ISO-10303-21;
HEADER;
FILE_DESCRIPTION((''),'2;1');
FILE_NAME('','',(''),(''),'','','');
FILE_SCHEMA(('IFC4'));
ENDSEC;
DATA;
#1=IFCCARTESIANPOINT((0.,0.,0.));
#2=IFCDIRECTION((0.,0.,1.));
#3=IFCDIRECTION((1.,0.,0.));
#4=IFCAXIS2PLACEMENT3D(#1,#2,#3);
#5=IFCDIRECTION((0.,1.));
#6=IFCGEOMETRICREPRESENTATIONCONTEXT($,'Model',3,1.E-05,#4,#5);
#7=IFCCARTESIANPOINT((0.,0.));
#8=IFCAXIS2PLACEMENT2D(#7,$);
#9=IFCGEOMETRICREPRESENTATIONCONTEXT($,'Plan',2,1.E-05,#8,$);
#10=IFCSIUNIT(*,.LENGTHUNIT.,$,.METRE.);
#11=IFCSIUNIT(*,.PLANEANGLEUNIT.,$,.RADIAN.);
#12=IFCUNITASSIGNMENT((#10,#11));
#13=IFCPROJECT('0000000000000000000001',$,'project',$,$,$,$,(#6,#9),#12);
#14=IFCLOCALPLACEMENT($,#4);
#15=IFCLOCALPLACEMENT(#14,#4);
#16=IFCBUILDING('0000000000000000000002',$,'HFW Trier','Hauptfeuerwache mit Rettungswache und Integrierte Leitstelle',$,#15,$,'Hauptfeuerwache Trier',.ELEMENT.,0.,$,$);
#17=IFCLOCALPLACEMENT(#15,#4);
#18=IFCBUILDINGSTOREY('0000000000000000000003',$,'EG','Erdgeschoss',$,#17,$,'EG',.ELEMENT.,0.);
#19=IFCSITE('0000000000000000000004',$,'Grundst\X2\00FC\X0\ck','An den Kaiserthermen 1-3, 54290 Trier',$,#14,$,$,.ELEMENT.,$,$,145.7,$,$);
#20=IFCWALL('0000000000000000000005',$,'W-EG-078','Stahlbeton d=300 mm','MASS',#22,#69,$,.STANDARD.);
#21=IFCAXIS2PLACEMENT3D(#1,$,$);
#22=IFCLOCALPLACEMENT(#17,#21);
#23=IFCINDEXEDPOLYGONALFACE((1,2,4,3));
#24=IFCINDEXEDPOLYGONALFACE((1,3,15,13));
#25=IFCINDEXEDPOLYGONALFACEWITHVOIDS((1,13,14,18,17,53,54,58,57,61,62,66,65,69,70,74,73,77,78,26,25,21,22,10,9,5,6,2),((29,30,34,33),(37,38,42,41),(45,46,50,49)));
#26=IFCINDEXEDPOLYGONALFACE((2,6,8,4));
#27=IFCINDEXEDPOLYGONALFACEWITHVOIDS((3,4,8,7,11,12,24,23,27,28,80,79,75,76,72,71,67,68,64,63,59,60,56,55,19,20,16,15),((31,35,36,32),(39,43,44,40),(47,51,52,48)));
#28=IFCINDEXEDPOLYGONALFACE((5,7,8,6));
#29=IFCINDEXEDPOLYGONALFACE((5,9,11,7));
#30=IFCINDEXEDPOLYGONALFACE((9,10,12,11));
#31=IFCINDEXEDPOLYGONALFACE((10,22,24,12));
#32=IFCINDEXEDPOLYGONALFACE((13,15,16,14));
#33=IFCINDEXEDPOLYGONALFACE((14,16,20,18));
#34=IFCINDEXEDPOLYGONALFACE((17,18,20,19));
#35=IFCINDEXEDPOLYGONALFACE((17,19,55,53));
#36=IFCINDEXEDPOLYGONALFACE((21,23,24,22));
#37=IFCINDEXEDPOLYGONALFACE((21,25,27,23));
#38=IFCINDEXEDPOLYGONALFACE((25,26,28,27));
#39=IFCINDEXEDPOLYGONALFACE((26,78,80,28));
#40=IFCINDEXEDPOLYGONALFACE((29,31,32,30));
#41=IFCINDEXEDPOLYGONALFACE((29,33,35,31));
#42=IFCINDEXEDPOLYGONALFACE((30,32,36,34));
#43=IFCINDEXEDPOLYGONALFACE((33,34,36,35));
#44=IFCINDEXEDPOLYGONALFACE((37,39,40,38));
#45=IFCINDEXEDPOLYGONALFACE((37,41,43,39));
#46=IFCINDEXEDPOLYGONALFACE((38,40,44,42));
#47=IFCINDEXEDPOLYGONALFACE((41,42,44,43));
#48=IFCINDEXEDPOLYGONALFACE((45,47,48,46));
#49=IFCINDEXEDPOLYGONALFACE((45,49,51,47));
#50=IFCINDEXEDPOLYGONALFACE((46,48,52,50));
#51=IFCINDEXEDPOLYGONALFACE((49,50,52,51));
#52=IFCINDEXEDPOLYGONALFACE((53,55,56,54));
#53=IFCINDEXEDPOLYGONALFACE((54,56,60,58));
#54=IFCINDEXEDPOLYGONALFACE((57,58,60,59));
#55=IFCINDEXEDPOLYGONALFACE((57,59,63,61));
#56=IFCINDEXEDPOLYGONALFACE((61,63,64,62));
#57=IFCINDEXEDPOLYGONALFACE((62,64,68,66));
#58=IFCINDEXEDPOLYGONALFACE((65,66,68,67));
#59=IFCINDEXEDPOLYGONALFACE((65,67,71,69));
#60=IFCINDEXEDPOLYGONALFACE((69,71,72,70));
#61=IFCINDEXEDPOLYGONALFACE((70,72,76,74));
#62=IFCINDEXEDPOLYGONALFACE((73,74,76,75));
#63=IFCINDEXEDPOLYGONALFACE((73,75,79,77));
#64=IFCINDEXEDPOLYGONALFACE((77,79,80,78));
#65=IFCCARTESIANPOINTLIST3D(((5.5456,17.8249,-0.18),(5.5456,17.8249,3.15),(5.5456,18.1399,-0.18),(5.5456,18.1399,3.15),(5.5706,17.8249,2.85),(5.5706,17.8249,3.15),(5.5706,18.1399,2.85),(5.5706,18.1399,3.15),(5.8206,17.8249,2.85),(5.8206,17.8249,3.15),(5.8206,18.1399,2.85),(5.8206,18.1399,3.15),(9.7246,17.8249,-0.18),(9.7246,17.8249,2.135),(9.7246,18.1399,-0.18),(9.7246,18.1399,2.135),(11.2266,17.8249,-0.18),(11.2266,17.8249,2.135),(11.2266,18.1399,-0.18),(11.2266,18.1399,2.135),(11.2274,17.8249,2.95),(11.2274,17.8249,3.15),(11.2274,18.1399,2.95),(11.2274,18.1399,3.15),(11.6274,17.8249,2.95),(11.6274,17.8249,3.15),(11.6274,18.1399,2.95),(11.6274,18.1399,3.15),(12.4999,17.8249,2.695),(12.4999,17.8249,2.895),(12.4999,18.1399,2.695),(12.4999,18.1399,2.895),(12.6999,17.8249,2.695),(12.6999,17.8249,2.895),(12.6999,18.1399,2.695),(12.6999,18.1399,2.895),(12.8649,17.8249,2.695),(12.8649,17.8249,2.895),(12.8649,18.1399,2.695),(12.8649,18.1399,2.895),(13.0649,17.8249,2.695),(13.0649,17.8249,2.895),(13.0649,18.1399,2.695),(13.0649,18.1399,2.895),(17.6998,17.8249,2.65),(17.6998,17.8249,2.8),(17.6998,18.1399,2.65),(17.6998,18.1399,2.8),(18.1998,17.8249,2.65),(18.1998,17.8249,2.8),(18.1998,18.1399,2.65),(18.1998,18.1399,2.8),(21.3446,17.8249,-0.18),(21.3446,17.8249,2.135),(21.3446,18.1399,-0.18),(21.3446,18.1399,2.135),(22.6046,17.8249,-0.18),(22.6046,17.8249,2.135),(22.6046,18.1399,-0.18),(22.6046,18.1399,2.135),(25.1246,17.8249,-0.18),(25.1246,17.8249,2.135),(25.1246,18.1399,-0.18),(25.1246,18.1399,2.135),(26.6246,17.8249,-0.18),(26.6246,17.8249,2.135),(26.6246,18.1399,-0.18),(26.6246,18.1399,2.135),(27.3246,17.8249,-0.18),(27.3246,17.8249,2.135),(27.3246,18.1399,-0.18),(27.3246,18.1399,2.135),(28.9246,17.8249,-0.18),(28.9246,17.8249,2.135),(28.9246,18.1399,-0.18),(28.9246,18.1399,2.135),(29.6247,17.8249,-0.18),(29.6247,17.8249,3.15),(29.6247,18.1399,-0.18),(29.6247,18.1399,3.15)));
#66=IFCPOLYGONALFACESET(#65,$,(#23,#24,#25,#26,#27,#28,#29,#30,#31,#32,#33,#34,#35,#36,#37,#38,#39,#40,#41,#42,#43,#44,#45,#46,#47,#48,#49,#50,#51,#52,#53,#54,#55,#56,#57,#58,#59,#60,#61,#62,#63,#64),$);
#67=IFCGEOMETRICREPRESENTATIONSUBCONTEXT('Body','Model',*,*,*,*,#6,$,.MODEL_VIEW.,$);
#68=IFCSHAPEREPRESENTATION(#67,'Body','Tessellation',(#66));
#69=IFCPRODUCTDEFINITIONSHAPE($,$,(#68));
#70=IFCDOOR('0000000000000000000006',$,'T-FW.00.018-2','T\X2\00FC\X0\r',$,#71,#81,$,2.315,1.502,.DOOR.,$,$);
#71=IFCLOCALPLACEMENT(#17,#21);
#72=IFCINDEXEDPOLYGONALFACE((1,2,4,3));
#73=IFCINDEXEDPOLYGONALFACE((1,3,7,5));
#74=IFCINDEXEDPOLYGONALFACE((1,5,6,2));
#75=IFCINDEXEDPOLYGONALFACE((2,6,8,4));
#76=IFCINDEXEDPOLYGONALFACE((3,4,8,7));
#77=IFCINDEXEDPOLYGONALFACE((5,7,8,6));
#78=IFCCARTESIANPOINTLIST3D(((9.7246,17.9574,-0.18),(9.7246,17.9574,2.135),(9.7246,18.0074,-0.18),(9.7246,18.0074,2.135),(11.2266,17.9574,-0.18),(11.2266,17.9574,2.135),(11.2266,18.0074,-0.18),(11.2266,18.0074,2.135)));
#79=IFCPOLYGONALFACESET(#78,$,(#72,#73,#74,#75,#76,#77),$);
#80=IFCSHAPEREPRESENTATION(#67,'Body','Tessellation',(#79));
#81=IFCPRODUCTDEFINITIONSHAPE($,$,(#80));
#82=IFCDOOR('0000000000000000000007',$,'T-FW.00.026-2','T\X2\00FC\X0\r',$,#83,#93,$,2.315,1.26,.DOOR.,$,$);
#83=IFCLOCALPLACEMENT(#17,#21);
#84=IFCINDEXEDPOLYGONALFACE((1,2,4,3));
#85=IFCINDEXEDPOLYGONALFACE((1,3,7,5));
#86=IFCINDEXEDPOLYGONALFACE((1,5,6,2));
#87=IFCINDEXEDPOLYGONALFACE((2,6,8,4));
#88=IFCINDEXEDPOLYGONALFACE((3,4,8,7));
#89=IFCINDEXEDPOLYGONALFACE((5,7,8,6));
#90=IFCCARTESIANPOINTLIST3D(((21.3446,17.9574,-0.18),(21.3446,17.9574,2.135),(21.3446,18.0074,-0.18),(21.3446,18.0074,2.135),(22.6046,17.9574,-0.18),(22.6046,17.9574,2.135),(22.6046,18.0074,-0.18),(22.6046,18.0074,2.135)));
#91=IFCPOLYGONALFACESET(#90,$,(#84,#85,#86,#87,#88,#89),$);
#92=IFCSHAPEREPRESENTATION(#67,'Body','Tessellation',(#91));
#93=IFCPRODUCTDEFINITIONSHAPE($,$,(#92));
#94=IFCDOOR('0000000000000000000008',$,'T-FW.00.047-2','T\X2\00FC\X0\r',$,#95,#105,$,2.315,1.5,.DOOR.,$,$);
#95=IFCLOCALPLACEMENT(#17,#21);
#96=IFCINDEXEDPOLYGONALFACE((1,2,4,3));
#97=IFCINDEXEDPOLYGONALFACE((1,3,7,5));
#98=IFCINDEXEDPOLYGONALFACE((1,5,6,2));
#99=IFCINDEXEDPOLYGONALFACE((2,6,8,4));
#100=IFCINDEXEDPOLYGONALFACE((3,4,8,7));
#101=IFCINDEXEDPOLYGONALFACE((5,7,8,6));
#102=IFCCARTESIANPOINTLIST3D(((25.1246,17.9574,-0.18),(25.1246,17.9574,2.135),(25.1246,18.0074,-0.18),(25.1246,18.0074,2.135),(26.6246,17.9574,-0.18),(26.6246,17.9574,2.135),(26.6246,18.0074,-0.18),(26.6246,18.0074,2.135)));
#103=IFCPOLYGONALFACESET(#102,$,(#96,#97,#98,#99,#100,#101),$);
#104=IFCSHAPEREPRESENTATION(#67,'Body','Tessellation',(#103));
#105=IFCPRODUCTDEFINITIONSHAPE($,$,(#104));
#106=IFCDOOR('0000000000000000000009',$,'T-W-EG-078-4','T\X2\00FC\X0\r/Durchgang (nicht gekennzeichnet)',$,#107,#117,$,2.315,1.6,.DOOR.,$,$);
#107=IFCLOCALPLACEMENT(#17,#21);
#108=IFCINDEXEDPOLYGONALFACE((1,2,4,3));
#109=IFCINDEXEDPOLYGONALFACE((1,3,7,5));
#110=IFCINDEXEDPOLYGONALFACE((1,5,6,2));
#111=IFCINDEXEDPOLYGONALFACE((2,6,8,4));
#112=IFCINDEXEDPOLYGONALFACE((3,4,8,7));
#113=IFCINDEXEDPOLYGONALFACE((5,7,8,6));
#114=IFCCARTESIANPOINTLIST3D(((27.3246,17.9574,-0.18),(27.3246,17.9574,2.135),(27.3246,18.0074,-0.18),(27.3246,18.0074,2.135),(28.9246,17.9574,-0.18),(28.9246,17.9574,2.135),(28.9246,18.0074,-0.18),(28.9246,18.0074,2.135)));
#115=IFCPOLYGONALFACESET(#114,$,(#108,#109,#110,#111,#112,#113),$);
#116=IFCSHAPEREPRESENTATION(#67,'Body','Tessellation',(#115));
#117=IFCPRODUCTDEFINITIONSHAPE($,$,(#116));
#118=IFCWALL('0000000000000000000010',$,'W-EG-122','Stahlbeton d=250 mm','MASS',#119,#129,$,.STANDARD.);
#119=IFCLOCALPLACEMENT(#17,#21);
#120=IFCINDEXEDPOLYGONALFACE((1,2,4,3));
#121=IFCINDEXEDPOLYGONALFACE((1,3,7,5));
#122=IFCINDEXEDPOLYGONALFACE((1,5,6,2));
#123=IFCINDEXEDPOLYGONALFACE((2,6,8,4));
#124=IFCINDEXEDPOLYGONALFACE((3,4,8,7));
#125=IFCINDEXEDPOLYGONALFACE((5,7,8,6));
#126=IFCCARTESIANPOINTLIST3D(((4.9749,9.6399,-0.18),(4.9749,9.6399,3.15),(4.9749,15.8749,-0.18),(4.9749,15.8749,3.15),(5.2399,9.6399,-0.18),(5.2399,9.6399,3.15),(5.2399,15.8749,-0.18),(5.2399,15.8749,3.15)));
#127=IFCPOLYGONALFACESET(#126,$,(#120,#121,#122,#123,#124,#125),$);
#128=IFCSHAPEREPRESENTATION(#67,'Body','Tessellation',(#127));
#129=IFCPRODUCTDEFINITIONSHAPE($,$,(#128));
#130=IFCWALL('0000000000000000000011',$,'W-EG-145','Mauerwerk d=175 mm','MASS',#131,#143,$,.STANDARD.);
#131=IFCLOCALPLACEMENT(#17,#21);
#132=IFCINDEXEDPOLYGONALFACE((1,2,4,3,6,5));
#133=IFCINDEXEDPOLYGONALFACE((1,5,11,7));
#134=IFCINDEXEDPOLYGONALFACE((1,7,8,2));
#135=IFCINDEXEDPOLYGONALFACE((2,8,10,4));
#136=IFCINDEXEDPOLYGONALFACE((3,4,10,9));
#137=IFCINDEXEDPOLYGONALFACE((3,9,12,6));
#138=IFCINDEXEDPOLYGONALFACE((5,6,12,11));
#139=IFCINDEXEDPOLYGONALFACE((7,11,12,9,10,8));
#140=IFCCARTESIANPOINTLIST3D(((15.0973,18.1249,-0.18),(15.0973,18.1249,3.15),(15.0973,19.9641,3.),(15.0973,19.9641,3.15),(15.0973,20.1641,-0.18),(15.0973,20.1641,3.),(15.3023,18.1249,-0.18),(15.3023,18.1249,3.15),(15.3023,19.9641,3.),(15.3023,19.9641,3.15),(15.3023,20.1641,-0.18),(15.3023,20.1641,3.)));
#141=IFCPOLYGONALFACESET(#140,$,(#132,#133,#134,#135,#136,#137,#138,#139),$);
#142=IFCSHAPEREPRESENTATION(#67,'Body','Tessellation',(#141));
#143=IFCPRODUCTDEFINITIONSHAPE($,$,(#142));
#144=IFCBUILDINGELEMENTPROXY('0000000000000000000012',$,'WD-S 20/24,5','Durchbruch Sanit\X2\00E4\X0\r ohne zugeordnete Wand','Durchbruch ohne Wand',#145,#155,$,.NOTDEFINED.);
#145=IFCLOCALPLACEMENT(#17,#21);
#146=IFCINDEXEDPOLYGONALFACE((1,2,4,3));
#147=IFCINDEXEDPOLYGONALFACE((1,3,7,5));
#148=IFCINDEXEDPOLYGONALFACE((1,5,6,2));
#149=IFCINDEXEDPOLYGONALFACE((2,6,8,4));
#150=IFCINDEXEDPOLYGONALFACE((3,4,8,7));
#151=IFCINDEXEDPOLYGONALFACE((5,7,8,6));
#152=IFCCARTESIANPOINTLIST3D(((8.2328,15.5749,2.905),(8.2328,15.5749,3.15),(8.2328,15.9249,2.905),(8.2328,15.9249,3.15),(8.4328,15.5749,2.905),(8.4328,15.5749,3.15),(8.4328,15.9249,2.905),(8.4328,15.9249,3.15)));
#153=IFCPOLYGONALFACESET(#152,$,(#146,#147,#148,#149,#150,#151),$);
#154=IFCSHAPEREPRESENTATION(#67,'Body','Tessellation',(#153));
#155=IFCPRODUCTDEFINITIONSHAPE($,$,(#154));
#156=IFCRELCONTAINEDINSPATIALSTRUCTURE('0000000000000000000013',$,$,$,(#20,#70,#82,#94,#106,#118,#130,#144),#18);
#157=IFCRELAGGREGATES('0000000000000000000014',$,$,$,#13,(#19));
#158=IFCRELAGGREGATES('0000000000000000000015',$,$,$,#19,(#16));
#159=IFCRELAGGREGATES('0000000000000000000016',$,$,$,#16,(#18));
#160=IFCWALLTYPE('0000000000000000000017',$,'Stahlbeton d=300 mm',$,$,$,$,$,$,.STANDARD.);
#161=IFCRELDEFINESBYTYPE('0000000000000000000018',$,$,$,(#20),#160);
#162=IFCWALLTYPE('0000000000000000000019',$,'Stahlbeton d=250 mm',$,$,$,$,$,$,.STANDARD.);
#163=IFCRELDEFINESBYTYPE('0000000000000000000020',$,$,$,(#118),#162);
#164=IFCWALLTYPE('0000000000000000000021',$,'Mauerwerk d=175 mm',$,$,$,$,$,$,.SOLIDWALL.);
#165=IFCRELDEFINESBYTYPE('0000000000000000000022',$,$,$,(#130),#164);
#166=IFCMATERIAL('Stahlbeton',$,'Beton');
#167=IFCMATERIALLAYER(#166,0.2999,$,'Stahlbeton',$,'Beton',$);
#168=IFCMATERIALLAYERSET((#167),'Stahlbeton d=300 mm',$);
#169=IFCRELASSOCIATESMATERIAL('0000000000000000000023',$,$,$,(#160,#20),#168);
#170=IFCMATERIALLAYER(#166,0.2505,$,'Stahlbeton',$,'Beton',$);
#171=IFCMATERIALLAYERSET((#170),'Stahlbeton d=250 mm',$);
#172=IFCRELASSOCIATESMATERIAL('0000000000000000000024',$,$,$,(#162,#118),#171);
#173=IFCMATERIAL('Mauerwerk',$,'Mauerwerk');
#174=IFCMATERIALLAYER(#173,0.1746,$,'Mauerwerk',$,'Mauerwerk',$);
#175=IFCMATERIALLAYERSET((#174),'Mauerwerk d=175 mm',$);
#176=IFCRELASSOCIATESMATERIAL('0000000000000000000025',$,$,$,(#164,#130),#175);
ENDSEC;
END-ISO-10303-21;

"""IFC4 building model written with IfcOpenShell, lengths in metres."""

from ifc_helpers import new_model, si_unit, direction, frame, frame_2d, origin_with_axes, origin_2d, place, context, subcontext, project, spatial, rectangle, extrude, material, layer, layer_set, layer_usage, type_object, element, fill, save


model = new_model("IFC4")

# Units and contexts
model_context = context("Model", 3, precision=1e-05, world=origin_with_axes(), true_north=direction((0.0, 1.0)))
plan_context = context("Plan", 2, precision=1e-05, world=origin_2d())
body_context = subcontext(model_context, "Body", "Model", "MODEL_VIEW")
ifc_project = project(units=[si_unit("LENGTHUNIT", "METRE"), si_unit("PLANEANGLEUNIT", "RADIAN")], contexts=[model_context, plan_context])

# Site, building, storey
site_placement = place(None, origin_with_axes())
site = spatial("IfcSite", under=ifc_project, at=site_placement, Name="Grundstück", Description="An den Kaiserthermen 1-3, 54290 Trier", CompositionType="ELEMENT", RefElevation=145.7)
building_placement = place(site_placement, origin_with_axes())
building = spatial("IfcBuilding", under=site, at=building_placement, Name="HFW Trier", Description="Hauptfeuerwache mit Rettungswache und Integrierte Leitstelle", LongName="Hauptfeuerwache Trier", CompositionType="ELEMENT", ElevationOfRefHeight=0.0)
storey_placement = place(building_placement, origin_with_axes())
storey = spatial("IfcBuildingStorey", under=building, at=storey_placement, Name="EG", Description="Erdgeschoss", LongName="EG", CompositionType="ELEMENT", Elevation=0.0)

# Wall, openings, doors
ifc_material_1 = material(Name="Stahlbeton", Category="Beton")
ifc_layer_1 = layer(ifc_material_1, 0.2999, Name="Stahlbeton", Category="Beton")
ifc_layer_set_1 = layer_set([ifc_layer_1], Name="Stahlbeton d=300 mm")
ifc_layer_usage_1 = layer_usage(ifc_layer_set_1, "AXIS2", "POSITIVE", -0.1575)
wall_type_1 = type_object("IfcWallType", Name="Stahlbeton d=300 mm", PredefinedType="STANDARD", material=ifc_layer_set_1)
wall_1_placement = place(storey_placement, frame((5.5456, 17.9824, -0.18), z_axis=(0.0, 0.0, 1.0), x_axis=(1.0, 0.0, 0.0)))
wall_1 = element("IfcWall", 1, at=wall_1_placement, inside=storey, type_object=wall_type_1, material=ifc_layer_usage_1, Name="W-EG-078", Description="Stahlbeton d=300 mm", ObjectType="MASS", PredefinedType="STANDARD", context=body_context, shape_type="SweptSolid", body=[
    extrude(rectangle(XDim=24.0791, YDim=0.315, at=frame_2d((12.0396, 0.0))), origin_with_axes(), (0.0, 0.0, 1.0), 3.33),
])
opening_1_placement = place(wall_1_placement, frame((4.179, 0.0, 0.0), z_axis=(0.0, 0.0, 1.0), x_axis=(1.0, 0.0, 0.0)))
opening_1 = element("IfcOpeningElement", 2, at=opening_1_placement, cuts=wall_1, PredefinedType="OPENING", context=body_context, shape_type="SweptSolid", body=[
    extrude(rectangle(XDim=1.502, YDim=0.415, at=frame_2d((0.751, 0.0))), origin_with_axes(), (0.0, 0.0, 1.0), 2.315),
])
opening_2_placement = place(wall_1_placement, frame((15.799, 0.0, 0.0), z_axis=(0.0, 0.0, 1.0), x_axis=(1.0, 0.0, 0.0)))
opening_2 = element("IfcOpeningElement", 3, at=opening_2_placement, cuts=wall_1, PredefinedType="OPENING", context=body_context, shape_type="SweptSolid", body=[
    extrude(rectangle(XDim=1.26, YDim=0.415, at=frame_2d((0.63, 0.0))), origin_with_axes(), (0.0, 0.0, 1.0), 2.315),
])
opening_3_placement = place(wall_1_placement, frame((19.579, 0.0, 0.0), z_axis=(0.0, 0.0, 1.0), x_axis=(1.0, 0.0, 0.0)))
opening_3 = element("IfcOpeningElement", 4, at=opening_3_placement, cuts=wall_1, PredefinedType="OPENING", context=body_context, shape_type="SweptSolid", body=[
    extrude(rectangle(XDim=1.5, YDim=0.415, at=frame_2d((0.75, 0.0))), origin_with_axes(), (0.0, 0.0, 1.0), 2.315),
])
opening_4_placement = place(wall_1_placement, frame((21.779, 0.0, 0.0), z_axis=(0.0, 0.0, 1.0), x_axis=(1.0, 0.0, 0.0)))
opening_4 = element("IfcOpeningElement", 5, at=opening_4_placement, cuts=wall_1, PredefinedType="OPENING", context=body_context, shape_type="SweptSolid", body=[
    extrude(rectangle(XDim=1.6, YDim=0.415, at=frame_2d((0.8, 0.0))), origin_with_axes(), (0.0, 0.0, 1.0), 2.315),
])
opening_5_placement = place(wall_1_placement, origin_with_axes())
element("IfcOpeningElement", 6, at=opening_5_placement, cuts=wall_1, ObjectType="Wanddurchbruch", PredefinedType="OPENING", context=body_context, shape_type="SweptSolid", body=[
    extrude(rectangle(XDim=0.2, YDim=0.415, at=frame_2d((7.0543, 0.0))), frame((0.0, 0.0, 2.875), z_axis=(0.0, 0.0, 1.0), x_axis=(1.0, 0.0, 0.0)), (0.0, 0.0, 1.0), 0.2),
])
opening_6_placement = place(wall_1_placement, origin_with_axes())
element("IfcOpeningElement", 7, at=opening_6_placement, cuts=wall_1, ObjectType="Wanddurchbruch", PredefinedType="OPENING", context=body_context, shape_type="SweptSolid", body=[
    extrude(rectangle(XDim=0.2, YDim=0.415, at=frame_2d((7.4193, 0.0))), frame((0.0, 0.0, 2.875), z_axis=(0.0, 0.0, 1.0), x_axis=(1.0, 0.0, 0.0)), (0.0, 0.0, 1.0), 0.2),
])
opening_7_placement = place(wall_1_placement, origin_with_axes())
element("IfcOpeningElement", 8, at=opening_7_placement, cuts=wall_1, ObjectType="Wanddurchbruch", PredefinedType="OPENING", context=body_context, shape_type="SweptSolid", body=[
    extrude(rectangle(XDim=0.4, YDim=0.415, at=frame_2d((5.8818, 0.0))), frame((0.0, 0.0, 3.13), z_axis=(0.0, 0.0, 1.0), x_axis=(1.0, 0.0, 0.0)), (0.0, 0.0, 1.0), 0.2),
])
opening_8_placement = place(wall_1_placement, origin_with_axes())
element("IfcOpeningElement", 9, at=opening_8_placement, cuts=wall_1, ObjectType="Wanddurchbruch", PredefinedType="OPENING", context=body_context, shape_type="SweptSolid", body=[
    extrude(rectangle(XDim=0.5, YDim=0.415, at=frame_2d((12.4042, 0.0))), frame((0.0, 0.0, 2.83), z_axis=(0.0, 0.0, 1.0), x_axis=(1.0, 0.0, 0.0)), (0.0, 0.0, 1.0), 0.15),
])
opening_9_placement = place(wall_1_placement, origin_with_axes())
element("IfcOpeningElement", 10, at=opening_9_placement, cuts=wall_1, ObjectType="Wanddurchbruch", PredefinedType="OPENING", context=body_context, shape_type="SweptSolid", body=[
    extrude(rectangle(XDim=0.25, YDim=0.415, at=frame_2d((0.15, 0.0))), frame((0.0, 0.0, 3.03), z_axis=(0.0, 0.0, 1.0), x_axis=(1.0, 0.0, 0.0)), (0.0, 0.0, 1.0), 0.3),
])
door_1_placement = place(wall_1_placement, frame((4.179, 0.0, 0.0), z_axis=(0.0, 0.0, 1.0), x_axis=(1.0, 0.0, 0.0)))
door_1 = element("IfcDoor", 11, at=door_1_placement, inside=storey, Name="T-FW.00.018-2", Description="Tür", OverallHeight=2.315, OverallWidth=1.502, PredefinedType="DOOR", context=body_context, shape_type="SweptSolid", body=[
    extrude(rectangle(XDim=1.502, YDim=0.05, at=frame_2d((0.751, 0.0))), origin_with_axes(), (0.0, 0.0, 1.0), 2.315),
])
fill(opening_1, door_1)
door_2_placement = place(wall_1_placement, frame((15.799, 0.0, 0.0), z_axis=(0.0, 0.0, 1.0), x_axis=(1.0, 0.0, 0.0)))
door_2 = element("IfcDoor", 12, at=door_2_placement, inside=storey, Name="T-FW.00.026-2", Description="Tür", OverallHeight=2.315, OverallWidth=1.26, PredefinedType="DOOR", context=body_context, shape_type="SweptSolid", body=[
    extrude(rectangle(XDim=1.26, YDim=0.05, at=frame_2d((0.63, 0.0))), origin_with_axes(), (0.0, 0.0, 1.0), 2.315),
])
fill(opening_2, door_2)
door_3_placement = place(wall_1_placement, frame((19.579, 0.0, 0.0), z_axis=(0.0, 0.0, 1.0), x_axis=(1.0, 0.0, 0.0)))
door_3 = element("IfcDoor", 13, at=door_3_placement, inside=storey, Name="T-FW.00.047-2", Description="Tür", OverallHeight=2.315, OverallWidth=1.5, PredefinedType="DOOR", context=body_context, shape_type="SweptSolid", body=[
    extrude(rectangle(XDim=1.5, YDim=0.05, at=frame_2d((0.75, 0.0))), origin_with_axes(), (0.0, 0.0, 1.0), 2.315),
])
fill(opening_3, door_3)
door_4_placement = place(wall_1_placement, frame((21.779, 0.0, 0.0), z_axis=(0.0, 0.0, 1.0), x_axis=(1.0, 0.0, 0.0)))
door_4 = element("IfcDoor", 14, at=door_4_placement, inside=storey, Name="T-W-EG-078-4", Description="Tür/Durchgang (nicht gekennzeichnet)", OverallHeight=2.315, OverallWidth=1.6, PredefinedType="DOOR", context=body_context, shape_type="SweptSolid", body=[
    extrude(rectangle(XDim=1.6, YDim=0.05, at=frame_2d((0.8, 0.0))), origin_with_axes(), (0.0, 0.0, 1.0), 2.315),
])
fill(opening_4, door_4)

# Wall
ifc_layer_2 = layer(ifc_material_1, 0.2505, Name="Stahlbeton", Category="Beton")
ifc_layer_set_2 = layer_set([ifc_layer_2], Name="Stahlbeton d=250 mm")
ifc_layer_usage_2 = layer_usage(ifc_layer_set_2, "AXIS2", "POSITIVE", -0.1325)
wall_type_2 = type_object("IfcWallType", Name="Stahlbeton d=250 mm", PredefinedType="STANDARD", material=ifc_layer_set_2)
wall_2_placement = place(storey_placement, frame((5.1074, 15.8749, -0.18), z_axis=(0.0, 0.0, 1.0), x_axis=(0.0, -1.0, 0.0)))
element("IfcWall", 15, at=wall_2_placement, inside=storey, type_object=wall_type_2, material=ifc_layer_usage_2, Name="W-EG-122", Description="Stahlbeton d=250 mm", ObjectType="MASS", PredefinedType="STANDARD", context=body_context, shape_type="SweptSolid", body=[
    extrude(rectangle(XDim=6.235, YDim=0.265, at=frame_2d((3.1175, 0.0))), origin_with_axes(), (0.0, 0.0, 1.0), 3.33),
])

# Wall, opening
ifc_material_2 = material(Name="Mauerwerk", Category="Mauerwerk")
ifc_layer_3 = layer(ifc_material_2, 0.1746, Name="Mauerwerk", Category="Mauerwerk")
ifc_layer_set_3 = layer_set([ifc_layer_3], Name="Mauerwerk d=175 mm")
ifc_layer_usage_3 = layer_usage(ifc_layer_set_3, "AXIS2", "POSITIVE", -0.1025)
wall_type_3 = type_object("IfcWallType", Name="Mauerwerk d=175 mm", PredefinedType="SOLIDWALL", material=ifc_layer_set_3)
wall_3_placement = place(storey_placement, frame((15.1998, 20.1641, -0.18), z_axis=(0.0, 0.0, 1.0), x_axis=(0.0, -1.0, 0.0)))
wall_3 = element("IfcWall", 16, at=wall_3_placement, inside=storey, type_object=wall_type_3, material=ifc_layer_usage_3, Name="W-EG-145", Description="Mauerwerk d=175 mm", ObjectType="MASS", PredefinedType="STANDARD", context=body_context, shape_type="SweptSolid", body=[
    extrude(rectangle(XDim=2.0392, YDim=0.205, at=frame_2d((1.0196, 0.0))), origin_with_axes(), (0.0, 0.0, 1.0), 3.33),
])
opening_10_placement = place(wall_3_placement, origin_with_axes())
element("IfcOpeningElement", 17, at=opening_10_placement, cuts=wall_3, ObjectType="Wanddurchbruch", PredefinedType="OPENING", context=body_context, shape_type="SweptSolid", body=[
    extrude(rectangle(XDim=0.2, YDim=0.305, at=frame_2d((0.1, 0.0))), frame((0.0, 0.0, 3.18), z_axis=(0.0, 0.0, 1.0), x_axis=(1.0, 0.0, 0.0)), (0.0, 0.0, 1.0), 0.15),
])

# Building element proxy
proxy_placement = place(storey_placement, frame((8.3328, 15.7499, 2.905), z_axis=(0.0, 0.0, 1.0), x_axis=(1.0, 0.0, 0.0)))
element("IfcBuildingElementProxy", 18, at=proxy_placement, inside=storey, Name="WD-S 20/24,5", Description="Durchbruch Sanitär ohne zugeordnete Wand", ObjectType="Durchbruch ohne Wand", PredefinedType="NOTDEFINED", context=body_context, shape_type="SweptSolid", body=[
    extrude(rectangle(XDim=0.2, YDim=0.35, at=origin_2d()), origin_with_axes(), (0.0, 0.0, 1.0), 0.245),
])

save(model, "model.ifc")
